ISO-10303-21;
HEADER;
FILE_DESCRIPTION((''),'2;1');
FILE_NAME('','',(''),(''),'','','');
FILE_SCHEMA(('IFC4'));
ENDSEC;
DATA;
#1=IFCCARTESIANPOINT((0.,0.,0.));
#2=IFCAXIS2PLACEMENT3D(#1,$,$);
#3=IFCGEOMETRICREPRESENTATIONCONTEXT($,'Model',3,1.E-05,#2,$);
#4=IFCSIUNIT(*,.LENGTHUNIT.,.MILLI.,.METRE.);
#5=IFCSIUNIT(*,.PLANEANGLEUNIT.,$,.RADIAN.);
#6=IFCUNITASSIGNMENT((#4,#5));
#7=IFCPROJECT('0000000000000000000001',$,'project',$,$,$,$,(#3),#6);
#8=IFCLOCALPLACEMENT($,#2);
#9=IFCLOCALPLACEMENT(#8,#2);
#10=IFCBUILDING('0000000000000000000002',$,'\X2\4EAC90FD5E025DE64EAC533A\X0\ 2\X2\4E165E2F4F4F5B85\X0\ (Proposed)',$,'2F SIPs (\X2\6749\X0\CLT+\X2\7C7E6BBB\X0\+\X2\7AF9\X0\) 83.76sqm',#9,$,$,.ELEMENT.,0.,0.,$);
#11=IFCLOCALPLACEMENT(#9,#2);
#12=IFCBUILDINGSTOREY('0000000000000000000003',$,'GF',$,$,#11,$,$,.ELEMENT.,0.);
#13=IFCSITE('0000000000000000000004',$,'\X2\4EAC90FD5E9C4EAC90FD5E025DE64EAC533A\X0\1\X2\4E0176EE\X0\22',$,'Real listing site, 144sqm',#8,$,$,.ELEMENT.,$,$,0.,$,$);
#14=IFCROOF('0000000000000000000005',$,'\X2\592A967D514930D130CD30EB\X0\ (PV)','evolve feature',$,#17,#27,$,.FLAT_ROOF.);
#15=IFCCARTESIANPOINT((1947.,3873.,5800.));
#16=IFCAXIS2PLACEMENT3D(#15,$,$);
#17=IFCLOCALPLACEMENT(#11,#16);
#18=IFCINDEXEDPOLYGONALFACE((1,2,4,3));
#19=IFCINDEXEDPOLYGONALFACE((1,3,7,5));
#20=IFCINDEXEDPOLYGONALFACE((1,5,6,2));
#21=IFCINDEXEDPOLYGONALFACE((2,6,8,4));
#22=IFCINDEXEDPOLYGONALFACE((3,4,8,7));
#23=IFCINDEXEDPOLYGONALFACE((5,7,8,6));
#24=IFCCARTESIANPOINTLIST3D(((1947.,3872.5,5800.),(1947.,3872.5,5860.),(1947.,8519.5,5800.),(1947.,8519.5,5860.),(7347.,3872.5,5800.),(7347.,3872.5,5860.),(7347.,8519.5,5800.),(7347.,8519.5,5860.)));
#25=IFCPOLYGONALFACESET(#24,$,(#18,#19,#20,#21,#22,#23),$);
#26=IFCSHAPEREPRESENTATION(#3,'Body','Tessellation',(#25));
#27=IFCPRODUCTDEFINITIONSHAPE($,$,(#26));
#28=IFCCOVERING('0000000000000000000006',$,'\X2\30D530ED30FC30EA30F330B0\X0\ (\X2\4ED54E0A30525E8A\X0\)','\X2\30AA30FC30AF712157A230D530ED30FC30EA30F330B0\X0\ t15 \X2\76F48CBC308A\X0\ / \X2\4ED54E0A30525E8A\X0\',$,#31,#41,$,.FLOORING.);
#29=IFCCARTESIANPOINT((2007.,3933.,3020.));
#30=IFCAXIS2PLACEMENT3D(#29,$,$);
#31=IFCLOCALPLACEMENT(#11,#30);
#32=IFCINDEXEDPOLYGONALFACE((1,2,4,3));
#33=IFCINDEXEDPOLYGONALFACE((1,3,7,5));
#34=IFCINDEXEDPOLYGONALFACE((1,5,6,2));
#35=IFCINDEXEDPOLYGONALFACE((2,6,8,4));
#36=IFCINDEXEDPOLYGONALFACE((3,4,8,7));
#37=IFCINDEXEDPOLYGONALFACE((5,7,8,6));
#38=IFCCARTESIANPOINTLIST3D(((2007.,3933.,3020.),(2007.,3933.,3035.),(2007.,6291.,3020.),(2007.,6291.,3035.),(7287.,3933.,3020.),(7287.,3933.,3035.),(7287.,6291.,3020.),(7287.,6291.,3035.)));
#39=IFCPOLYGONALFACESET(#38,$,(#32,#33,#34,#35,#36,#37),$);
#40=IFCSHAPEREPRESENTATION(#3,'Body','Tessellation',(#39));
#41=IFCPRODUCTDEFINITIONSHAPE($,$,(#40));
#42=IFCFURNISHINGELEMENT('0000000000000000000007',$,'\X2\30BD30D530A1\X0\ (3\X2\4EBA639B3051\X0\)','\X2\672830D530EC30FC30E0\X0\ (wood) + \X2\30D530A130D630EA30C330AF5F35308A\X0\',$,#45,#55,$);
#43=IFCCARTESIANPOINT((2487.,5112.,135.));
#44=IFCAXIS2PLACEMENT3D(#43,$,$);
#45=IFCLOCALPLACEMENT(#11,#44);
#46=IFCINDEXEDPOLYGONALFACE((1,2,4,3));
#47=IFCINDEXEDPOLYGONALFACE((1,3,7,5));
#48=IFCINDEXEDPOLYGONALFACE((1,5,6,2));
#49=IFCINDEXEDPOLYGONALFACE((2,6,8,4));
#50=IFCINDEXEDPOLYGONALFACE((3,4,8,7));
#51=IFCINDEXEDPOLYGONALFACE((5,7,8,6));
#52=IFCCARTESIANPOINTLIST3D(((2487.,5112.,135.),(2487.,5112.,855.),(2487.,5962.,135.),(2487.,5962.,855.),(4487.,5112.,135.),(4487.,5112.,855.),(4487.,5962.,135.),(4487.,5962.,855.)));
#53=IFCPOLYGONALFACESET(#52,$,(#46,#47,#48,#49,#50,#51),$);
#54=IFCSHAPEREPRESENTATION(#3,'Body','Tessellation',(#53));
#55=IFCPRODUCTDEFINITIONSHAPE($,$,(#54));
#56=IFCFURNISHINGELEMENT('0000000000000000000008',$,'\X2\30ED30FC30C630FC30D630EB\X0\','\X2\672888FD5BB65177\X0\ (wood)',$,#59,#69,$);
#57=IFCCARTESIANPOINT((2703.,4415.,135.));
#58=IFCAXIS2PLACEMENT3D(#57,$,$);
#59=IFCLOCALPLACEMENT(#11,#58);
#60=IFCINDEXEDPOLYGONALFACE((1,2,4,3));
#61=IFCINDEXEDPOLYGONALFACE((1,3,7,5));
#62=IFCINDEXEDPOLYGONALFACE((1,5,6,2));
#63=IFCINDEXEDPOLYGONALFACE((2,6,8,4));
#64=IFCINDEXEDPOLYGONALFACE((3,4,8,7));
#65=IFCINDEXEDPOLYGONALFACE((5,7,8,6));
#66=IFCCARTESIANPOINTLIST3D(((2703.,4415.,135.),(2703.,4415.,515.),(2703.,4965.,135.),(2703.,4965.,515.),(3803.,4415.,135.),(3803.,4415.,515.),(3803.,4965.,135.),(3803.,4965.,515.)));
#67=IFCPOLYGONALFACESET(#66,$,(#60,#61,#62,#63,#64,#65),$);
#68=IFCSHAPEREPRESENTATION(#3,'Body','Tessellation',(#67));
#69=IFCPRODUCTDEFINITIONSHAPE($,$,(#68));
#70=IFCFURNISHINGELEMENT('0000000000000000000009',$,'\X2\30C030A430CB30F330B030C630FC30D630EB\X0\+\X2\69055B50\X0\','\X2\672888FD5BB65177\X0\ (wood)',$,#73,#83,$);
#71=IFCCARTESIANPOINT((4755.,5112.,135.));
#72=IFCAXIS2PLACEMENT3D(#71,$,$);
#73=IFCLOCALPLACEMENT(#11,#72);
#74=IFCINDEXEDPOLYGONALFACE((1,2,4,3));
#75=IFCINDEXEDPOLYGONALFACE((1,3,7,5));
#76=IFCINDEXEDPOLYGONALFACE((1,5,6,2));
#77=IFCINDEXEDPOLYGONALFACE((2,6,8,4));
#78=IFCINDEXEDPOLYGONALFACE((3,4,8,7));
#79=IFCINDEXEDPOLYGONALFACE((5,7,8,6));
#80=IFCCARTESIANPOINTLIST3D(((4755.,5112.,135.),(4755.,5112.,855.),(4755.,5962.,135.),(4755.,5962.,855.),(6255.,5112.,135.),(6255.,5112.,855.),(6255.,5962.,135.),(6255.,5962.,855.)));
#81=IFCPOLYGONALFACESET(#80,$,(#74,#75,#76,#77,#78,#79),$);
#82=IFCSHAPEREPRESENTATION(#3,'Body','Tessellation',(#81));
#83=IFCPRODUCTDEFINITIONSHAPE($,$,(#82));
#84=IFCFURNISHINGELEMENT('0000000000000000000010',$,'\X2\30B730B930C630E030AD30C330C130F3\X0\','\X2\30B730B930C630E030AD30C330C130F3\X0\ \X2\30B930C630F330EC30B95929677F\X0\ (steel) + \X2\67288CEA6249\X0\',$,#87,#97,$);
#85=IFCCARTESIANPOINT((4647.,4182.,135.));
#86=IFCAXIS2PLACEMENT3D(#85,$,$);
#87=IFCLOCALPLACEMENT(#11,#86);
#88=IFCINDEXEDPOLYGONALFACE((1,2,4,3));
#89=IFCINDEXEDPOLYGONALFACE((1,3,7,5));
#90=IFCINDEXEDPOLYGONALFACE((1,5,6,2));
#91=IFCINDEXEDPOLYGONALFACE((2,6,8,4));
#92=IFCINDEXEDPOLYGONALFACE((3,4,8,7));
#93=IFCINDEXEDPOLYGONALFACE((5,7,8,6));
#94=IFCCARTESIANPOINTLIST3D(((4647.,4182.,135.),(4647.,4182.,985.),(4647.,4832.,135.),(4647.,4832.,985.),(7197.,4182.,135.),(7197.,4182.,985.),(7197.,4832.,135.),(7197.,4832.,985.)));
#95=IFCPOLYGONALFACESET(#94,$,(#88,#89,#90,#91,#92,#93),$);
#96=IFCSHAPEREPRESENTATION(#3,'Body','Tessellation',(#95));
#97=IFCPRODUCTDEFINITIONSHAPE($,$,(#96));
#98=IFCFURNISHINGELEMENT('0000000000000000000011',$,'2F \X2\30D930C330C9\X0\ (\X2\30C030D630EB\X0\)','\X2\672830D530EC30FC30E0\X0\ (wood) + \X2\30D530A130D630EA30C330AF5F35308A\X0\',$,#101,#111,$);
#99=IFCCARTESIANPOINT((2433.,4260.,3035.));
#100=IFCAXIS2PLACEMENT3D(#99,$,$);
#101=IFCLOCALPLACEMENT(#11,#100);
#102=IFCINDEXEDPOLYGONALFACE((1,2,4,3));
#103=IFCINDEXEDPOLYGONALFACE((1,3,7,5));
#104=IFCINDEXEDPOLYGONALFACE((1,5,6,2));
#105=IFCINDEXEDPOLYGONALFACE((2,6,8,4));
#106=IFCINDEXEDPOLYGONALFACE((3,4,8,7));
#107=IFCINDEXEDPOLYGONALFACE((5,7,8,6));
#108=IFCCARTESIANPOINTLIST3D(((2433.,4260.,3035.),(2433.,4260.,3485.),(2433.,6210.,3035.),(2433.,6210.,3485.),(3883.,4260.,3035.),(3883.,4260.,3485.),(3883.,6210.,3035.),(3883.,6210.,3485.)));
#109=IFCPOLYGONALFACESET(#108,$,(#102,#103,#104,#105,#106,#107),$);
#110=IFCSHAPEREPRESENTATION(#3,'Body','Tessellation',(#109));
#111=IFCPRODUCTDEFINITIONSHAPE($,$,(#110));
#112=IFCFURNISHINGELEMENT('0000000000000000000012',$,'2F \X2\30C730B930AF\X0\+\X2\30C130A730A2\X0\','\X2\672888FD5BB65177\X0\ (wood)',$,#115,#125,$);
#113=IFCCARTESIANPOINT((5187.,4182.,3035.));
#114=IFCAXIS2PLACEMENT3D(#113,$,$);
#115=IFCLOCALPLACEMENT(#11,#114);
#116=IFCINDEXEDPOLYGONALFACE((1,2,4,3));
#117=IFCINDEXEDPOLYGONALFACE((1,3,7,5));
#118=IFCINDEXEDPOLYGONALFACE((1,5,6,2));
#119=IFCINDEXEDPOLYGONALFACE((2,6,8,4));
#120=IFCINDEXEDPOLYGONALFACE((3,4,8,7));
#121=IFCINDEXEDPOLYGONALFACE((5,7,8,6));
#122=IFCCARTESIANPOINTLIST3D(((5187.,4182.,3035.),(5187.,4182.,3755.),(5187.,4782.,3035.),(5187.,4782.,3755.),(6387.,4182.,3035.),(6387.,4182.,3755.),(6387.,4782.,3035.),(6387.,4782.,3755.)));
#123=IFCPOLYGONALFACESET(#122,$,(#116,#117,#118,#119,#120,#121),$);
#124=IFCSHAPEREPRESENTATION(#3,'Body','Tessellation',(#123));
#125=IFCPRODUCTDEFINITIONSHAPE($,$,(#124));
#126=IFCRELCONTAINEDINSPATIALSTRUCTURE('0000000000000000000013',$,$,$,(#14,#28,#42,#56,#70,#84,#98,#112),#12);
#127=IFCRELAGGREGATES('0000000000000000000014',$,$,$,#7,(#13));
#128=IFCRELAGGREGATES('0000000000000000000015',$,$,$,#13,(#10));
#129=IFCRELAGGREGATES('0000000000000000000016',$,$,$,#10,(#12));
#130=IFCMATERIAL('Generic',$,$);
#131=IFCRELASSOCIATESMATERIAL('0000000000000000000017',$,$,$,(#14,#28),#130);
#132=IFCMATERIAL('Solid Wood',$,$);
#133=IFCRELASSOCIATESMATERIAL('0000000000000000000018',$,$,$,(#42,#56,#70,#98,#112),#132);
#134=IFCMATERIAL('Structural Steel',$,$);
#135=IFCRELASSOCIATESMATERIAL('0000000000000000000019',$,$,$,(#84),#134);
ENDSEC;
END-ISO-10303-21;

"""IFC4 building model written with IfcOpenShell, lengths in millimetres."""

from ifc_helpers import new_model, si_unit, frame, frame_2d, origin, place, context, project, spatial, rectangle, extrude, material, element, save


model = new_model("IFC4")

# Units and contexts
model_context = context("Model", 3, precision=1e-05, world=origin())
ifc_project = project(units=[si_unit("LENGTHUNIT", "METRE", prefix="MILLI"), si_unit("PLANEANGLEUNIT", "RADIAN")], contexts=[model_context])

# Site, building, storey
site_placement = place(None, origin())
site = spatial("IfcSite", under=ifc_project, at=site_placement, Name="京都府京都市左京区1丁目22", ObjectType="Real listing site, 144sqm", CompositionType="ELEMENT", RefElevation=0.0)
building_placement = place(site_placement, origin())
building = spatial("IfcBuilding", under=site, at=building_placement, Name="京都市左京区 2世帯住宅 (Proposed)", ObjectType="2F SIPs (杉CLT+籾殻+竹) 83.76sqm", CompositionType="ELEMENT", ElevationOfRefHeight=0.0, ElevationOfTerrain=0.0)
storey_placement = place(building_placement, origin())
storey = spatial("IfcBuildingStorey", under=building, at=storey_placement, Name="GF", CompositionType="ELEMENT", Elevation=0.0)

# Shared definitions
ifc_material_1 = material(Name="Solid Wood")

# Shared definitions
ifc_material_2 = material(Name="Generic")

# Roof
ifc_material_3 = material(Name="Structural Steel")
roof_1_placement = place(storey_placement, frame((1947.0, 3873.0, 5800.0)))
element("IfcRoof", 1, at=roof_1_placement, inside=storey, material=ifc_material_2, Name="太陽光パネル (PV)", Description="evolve feature", PredefinedType="FLAT_ROOF", context=model_context, shape_type="SweptSolid", body=[
    extrude(rectangle(XDim=5400.0, YDim=4647.0, at=frame_2d((2700.0, 2323.0))), frame((1947.0, 3873.0, 5800.0)), (0.0, 0.0, 1.0), 60.0),
])

# Covering
covering_placement = place(storey_placement, frame((2007.0, 3933.0, 3020.0)))
element("IfcCovering", 2, at=covering_placement, inside=storey, material=ifc_material_2, Name="フローリング (仕上げ床)", Description="オーク無垢フローリング t15 直貼り / 仕上げ床", PredefinedType="FLOORING", context=model_context, shape_type="SweptSolid", body=[
    extrude(rectangle(XDim=5280.0, YDim=2358.0, at=frame_2d((2640.0, 1179.0))), frame((2007.0, 3933.0, 3020.0)), (0.0, 0.0, 1.0), 15.0),
])

# Furnishing elements
furnishing_1_placement = place(storey_placement, frame((2487.0, 5112.0, 135.0)))
element("IfcFurnishingElement", 3, at=furnishing_1_placement, inside=storey, material=ifc_material_1, Name="ソファ (3人掛け)", Description="木フレーム (wood) + ファブリック張り", context=model_context, shape_type="SweptSolid", body=[
    extrude(rectangle(XDim=2000.0, YDim=850.0, at=frame_2d((1000.0, 425.0))), frame((2487.0, 5112.0, 135.0)), (0.0, 0.0, 1.0), 720.0),
])
furnishing_2_placement = place(storey_placement, frame((2703.0, 4415.0, 135.0)))
element("IfcFurnishingElement", 4, at=furnishing_2_placement, inside=storey, material=ifc_material_1, Name="ローテーブル", Description="木製家具 (wood)", context=model_context, shape_type="SweptSolid", body=[
    extrude(rectangle(XDim=1100.0, YDim=550.0, at=frame_2d((550.0, 275.0))), frame((2703.0, 4415.0, 135.0)), (0.0, 0.0, 1.0), 380.0),
])
furnishing_3_placement = place(storey_placement, frame((4755.0, 5112.0, 135.0)))
element("IfcFurnishingElement", 5, at=furnishing_3_placement, inside=storey, material=ifc_material_1, Name="ダイニングテーブル+椅子", Description="木製家具 (wood)", context=model_context, shape_type="SweptSolid", body=[
    extrude(rectangle(XDim=1500.0, YDim=850.0, at=frame_2d((750.0, 425.0))), frame((4755.0, 5112.0, 135.0)), (0.0, 0.0, 1.0), 720.0),
])
furnishing_4_placement = place(storey_placement, frame((4647.0, 4182.0, 135.0)))
element("IfcFurnishingElement", 6, at=furnishing_4_placement, inside=storey, material=ifc_material_3, Name="システムキッチン", Description="システムキッチン ステンレス天板 (steel) + 木質扉", context=model_context, shape_type="SweptSolid", body=[
    extrude(rectangle(XDim=2550.0, YDim=650.0, at=frame_2d((1275.0, 325.0))), frame((4647.0, 4182.0, 135.0)), (0.0, 0.0, 1.0), 850.0),
])
furnishing_5_placement = place(storey_placement, frame((2433.0, 4260.0, 3035.0)))
element("IfcFurnishingElement", 7, at=furnishing_5_placement, inside=storey, material=ifc_material_1, Name="2F ベッド (ダブル)", Description="木フレーム (wood) + ファブリック張り", context=model_context, shape_type="SweptSolid", body=[
    extrude(rectangle(XDim=1450.0, YDim=1950.0, at=frame_2d((725.0, 975.0))), frame((2433.0, 4260.0, 3035.0)), (0.0, 0.0, 1.0), 450.0),
])
furnishing_6_placement = place(storey_placement, frame((5187.0, 4182.0, 3035.0)))
element("IfcFurnishingElement", 8, at=furnishing_6_placement, inside=storey, material=ifc_material_1, Name="2F デスク+チェア", Description="木製家具 (wood)", context=model_context, shape_type="SweptSolid", body=[
    extrude(rectangle(XDim=1200.0, YDim=600.0, at=frame_2d((600.0, 300.0))), frame((5187.0, 4182.0, 3035.0)), (0.0, 0.0, 1.0), 720.0),
])

save(model, "model.ifc")
